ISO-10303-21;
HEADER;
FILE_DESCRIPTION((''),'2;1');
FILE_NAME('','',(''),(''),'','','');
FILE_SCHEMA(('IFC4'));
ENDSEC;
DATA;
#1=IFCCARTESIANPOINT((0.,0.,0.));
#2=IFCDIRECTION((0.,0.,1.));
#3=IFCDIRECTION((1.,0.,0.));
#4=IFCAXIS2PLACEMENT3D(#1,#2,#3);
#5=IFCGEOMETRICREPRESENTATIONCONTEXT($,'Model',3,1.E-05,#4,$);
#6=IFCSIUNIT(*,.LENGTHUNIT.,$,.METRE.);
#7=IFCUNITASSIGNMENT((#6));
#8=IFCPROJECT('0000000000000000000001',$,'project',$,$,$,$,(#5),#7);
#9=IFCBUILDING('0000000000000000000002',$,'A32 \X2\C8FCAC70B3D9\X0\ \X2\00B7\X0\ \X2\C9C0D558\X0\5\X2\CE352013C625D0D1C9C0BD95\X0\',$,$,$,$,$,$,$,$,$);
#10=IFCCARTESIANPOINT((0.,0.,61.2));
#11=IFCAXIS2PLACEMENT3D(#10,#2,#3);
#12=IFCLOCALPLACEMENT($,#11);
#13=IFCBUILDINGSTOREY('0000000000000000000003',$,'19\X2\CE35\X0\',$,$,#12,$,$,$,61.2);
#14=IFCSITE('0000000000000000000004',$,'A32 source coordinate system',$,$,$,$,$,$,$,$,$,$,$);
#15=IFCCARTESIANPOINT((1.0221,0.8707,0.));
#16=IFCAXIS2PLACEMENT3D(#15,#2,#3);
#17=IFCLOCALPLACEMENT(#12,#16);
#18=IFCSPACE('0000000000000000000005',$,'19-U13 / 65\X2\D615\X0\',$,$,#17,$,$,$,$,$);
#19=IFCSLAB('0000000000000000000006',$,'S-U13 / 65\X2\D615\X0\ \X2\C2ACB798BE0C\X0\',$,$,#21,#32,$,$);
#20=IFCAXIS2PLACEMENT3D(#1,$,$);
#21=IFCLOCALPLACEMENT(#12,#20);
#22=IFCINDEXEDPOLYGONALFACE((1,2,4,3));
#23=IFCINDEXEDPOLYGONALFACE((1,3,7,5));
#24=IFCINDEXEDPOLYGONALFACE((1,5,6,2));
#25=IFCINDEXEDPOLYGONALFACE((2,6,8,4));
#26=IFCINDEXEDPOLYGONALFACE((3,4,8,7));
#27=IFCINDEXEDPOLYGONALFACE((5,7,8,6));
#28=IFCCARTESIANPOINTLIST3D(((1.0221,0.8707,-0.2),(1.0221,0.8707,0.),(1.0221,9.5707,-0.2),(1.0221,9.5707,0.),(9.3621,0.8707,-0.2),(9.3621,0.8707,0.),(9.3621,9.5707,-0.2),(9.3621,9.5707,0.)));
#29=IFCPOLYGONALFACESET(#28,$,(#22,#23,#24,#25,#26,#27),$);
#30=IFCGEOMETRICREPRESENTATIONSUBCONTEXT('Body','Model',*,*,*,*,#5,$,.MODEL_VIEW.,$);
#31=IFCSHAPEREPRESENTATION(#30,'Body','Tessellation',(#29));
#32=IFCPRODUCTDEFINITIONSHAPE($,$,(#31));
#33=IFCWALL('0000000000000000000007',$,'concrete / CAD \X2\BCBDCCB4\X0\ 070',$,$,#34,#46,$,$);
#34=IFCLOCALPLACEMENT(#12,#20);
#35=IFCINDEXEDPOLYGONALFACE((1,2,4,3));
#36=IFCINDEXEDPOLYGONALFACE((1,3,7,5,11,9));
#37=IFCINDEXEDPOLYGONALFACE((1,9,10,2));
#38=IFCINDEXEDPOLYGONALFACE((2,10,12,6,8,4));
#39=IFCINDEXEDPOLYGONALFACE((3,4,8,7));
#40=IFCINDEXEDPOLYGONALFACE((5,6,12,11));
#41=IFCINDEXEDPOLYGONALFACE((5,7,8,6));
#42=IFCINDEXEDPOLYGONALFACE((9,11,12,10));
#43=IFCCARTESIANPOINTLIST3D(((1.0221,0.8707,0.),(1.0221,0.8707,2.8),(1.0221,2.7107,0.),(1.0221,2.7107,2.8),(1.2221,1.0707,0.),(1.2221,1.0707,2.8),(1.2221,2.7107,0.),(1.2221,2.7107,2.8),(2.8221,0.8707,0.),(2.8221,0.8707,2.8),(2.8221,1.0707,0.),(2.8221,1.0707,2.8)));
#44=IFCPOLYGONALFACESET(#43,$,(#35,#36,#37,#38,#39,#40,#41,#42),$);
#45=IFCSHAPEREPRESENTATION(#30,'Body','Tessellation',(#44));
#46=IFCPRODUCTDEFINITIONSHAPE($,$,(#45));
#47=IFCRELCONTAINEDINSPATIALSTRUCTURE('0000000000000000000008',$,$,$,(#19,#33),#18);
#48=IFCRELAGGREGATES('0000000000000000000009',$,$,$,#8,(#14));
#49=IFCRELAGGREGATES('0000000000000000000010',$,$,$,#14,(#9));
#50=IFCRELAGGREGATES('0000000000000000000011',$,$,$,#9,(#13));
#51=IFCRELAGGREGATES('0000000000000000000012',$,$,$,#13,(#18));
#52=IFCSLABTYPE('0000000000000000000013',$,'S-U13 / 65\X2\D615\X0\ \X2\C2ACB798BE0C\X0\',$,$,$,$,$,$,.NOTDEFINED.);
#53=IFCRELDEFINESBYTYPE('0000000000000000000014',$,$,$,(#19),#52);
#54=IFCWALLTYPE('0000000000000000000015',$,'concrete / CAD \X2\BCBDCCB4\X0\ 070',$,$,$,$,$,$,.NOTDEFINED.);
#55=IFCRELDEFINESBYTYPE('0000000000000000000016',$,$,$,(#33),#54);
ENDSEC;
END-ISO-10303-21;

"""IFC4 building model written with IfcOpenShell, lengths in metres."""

from ifc_helpers import new_model, si_unit, frame, origin, origin_with_axes, place, context, subcontext, project, spatial, polyline, outline, extrude, source, transform, mapped, type_object, type_shapes, element, save


model = new_model("IFC4")

# Units and contexts
model_context = context("Model", 3, precision=1e-05, world=origin_with_axes())
body_context = subcontext(model_context, "Body", "Model", "MODEL_VIEW")
ifc_project = project(units=[si_unit("LENGTHUNIT", "METRE")], contexts=[model_context])

# Site, building, storey, space
storey_placement = place(None, frame((0.0, 0.0, 61.2), z_axis=(0.0, 0.0, 1.0), x_axis=(1.0, 0.0, 0.0)))
space_placement = place(storey_placement, frame((1.0221, 0.8707, 0.0), z_axis=(0.0, 0.0, 1.0), x_axis=(1.0, 0.0, 0.0)))
site = spatial("IfcSite", under=ifc_project, Name="A32 source coordinate system")
building = spatial("IfcBuilding", under=site, Name="A32 주거동 · 지하5층–옥탑지붕")
storey = spatial("IfcBuildingStorey", under=building, at=storey_placement, Name="19층", Elevation=61.2)
space = spatial("IfcSpace", under=storey, at=space_placement, Name="19-U13 / 65형")

# Slab
slab_type = type_object("IfcSlabType", Name="S-U13 / 65형 슬래브", PredefinedType="NOTDEFINED")
shared_shape_1 = source(origin(), body_context, "Body", "SweptSolid", [
    extrude(outline(polyline([(0.0, 0.0), (0.0, 8.7), (8.34, 8.7), (8.34, 0.0), (0.0, 0.0)])), frame((0.0, 0.0, -0.2)), (0.0, 0.0, 1.0), 0.2),
])
type_shapes(slab_type, [shared_shape_1])
slab_placement = place(space_placement, origin_with_axes())
element("IfcSlab", 1, at=slab_placement, inside=space, type_object=slab_type, Name="S-U13 / 65형 슬래브", context=body_context, shape_type="MappedRepresentation", body=[
    mapped(shared_shape_1, transform((0.0, 0.0, 0.0), scale=1.0)),
])

# Wall
wall_type_1 = type_object("IfcWallType", Name="concrete / CAD 벽체 070", PredefinedType="NOTDEFINED")
shared_shape_2 = source(origin(), body_context, "Body", "SweptSolid", [
    extrude(outline(polyline([(0.2, 1.84), (0.2, 0.2), (1.8, 0.2), (1.8, 0.0), (0.0, 0.0), (0.0, 1.84), (0.2, 1.84)])), origin(), (0.0, 0.0, 1.0), 2.8),
])
type_shapes(wall_type_1, [shared_shape_2])
wall_1_placement = place(space_placement, origin_with_axes())
element("IfcWall", 2, at=wall_1_placement, inside=space, type_object=wall_type_1, Name="concrete / CAD 벽체 070", context=body_context, shape_type="MappedRepresentation", body=[
    mapped(shared_shape_2, transform((0.0, 0.0, 0.0), scale=1.0)),
])

save(model, "model.ifc")
